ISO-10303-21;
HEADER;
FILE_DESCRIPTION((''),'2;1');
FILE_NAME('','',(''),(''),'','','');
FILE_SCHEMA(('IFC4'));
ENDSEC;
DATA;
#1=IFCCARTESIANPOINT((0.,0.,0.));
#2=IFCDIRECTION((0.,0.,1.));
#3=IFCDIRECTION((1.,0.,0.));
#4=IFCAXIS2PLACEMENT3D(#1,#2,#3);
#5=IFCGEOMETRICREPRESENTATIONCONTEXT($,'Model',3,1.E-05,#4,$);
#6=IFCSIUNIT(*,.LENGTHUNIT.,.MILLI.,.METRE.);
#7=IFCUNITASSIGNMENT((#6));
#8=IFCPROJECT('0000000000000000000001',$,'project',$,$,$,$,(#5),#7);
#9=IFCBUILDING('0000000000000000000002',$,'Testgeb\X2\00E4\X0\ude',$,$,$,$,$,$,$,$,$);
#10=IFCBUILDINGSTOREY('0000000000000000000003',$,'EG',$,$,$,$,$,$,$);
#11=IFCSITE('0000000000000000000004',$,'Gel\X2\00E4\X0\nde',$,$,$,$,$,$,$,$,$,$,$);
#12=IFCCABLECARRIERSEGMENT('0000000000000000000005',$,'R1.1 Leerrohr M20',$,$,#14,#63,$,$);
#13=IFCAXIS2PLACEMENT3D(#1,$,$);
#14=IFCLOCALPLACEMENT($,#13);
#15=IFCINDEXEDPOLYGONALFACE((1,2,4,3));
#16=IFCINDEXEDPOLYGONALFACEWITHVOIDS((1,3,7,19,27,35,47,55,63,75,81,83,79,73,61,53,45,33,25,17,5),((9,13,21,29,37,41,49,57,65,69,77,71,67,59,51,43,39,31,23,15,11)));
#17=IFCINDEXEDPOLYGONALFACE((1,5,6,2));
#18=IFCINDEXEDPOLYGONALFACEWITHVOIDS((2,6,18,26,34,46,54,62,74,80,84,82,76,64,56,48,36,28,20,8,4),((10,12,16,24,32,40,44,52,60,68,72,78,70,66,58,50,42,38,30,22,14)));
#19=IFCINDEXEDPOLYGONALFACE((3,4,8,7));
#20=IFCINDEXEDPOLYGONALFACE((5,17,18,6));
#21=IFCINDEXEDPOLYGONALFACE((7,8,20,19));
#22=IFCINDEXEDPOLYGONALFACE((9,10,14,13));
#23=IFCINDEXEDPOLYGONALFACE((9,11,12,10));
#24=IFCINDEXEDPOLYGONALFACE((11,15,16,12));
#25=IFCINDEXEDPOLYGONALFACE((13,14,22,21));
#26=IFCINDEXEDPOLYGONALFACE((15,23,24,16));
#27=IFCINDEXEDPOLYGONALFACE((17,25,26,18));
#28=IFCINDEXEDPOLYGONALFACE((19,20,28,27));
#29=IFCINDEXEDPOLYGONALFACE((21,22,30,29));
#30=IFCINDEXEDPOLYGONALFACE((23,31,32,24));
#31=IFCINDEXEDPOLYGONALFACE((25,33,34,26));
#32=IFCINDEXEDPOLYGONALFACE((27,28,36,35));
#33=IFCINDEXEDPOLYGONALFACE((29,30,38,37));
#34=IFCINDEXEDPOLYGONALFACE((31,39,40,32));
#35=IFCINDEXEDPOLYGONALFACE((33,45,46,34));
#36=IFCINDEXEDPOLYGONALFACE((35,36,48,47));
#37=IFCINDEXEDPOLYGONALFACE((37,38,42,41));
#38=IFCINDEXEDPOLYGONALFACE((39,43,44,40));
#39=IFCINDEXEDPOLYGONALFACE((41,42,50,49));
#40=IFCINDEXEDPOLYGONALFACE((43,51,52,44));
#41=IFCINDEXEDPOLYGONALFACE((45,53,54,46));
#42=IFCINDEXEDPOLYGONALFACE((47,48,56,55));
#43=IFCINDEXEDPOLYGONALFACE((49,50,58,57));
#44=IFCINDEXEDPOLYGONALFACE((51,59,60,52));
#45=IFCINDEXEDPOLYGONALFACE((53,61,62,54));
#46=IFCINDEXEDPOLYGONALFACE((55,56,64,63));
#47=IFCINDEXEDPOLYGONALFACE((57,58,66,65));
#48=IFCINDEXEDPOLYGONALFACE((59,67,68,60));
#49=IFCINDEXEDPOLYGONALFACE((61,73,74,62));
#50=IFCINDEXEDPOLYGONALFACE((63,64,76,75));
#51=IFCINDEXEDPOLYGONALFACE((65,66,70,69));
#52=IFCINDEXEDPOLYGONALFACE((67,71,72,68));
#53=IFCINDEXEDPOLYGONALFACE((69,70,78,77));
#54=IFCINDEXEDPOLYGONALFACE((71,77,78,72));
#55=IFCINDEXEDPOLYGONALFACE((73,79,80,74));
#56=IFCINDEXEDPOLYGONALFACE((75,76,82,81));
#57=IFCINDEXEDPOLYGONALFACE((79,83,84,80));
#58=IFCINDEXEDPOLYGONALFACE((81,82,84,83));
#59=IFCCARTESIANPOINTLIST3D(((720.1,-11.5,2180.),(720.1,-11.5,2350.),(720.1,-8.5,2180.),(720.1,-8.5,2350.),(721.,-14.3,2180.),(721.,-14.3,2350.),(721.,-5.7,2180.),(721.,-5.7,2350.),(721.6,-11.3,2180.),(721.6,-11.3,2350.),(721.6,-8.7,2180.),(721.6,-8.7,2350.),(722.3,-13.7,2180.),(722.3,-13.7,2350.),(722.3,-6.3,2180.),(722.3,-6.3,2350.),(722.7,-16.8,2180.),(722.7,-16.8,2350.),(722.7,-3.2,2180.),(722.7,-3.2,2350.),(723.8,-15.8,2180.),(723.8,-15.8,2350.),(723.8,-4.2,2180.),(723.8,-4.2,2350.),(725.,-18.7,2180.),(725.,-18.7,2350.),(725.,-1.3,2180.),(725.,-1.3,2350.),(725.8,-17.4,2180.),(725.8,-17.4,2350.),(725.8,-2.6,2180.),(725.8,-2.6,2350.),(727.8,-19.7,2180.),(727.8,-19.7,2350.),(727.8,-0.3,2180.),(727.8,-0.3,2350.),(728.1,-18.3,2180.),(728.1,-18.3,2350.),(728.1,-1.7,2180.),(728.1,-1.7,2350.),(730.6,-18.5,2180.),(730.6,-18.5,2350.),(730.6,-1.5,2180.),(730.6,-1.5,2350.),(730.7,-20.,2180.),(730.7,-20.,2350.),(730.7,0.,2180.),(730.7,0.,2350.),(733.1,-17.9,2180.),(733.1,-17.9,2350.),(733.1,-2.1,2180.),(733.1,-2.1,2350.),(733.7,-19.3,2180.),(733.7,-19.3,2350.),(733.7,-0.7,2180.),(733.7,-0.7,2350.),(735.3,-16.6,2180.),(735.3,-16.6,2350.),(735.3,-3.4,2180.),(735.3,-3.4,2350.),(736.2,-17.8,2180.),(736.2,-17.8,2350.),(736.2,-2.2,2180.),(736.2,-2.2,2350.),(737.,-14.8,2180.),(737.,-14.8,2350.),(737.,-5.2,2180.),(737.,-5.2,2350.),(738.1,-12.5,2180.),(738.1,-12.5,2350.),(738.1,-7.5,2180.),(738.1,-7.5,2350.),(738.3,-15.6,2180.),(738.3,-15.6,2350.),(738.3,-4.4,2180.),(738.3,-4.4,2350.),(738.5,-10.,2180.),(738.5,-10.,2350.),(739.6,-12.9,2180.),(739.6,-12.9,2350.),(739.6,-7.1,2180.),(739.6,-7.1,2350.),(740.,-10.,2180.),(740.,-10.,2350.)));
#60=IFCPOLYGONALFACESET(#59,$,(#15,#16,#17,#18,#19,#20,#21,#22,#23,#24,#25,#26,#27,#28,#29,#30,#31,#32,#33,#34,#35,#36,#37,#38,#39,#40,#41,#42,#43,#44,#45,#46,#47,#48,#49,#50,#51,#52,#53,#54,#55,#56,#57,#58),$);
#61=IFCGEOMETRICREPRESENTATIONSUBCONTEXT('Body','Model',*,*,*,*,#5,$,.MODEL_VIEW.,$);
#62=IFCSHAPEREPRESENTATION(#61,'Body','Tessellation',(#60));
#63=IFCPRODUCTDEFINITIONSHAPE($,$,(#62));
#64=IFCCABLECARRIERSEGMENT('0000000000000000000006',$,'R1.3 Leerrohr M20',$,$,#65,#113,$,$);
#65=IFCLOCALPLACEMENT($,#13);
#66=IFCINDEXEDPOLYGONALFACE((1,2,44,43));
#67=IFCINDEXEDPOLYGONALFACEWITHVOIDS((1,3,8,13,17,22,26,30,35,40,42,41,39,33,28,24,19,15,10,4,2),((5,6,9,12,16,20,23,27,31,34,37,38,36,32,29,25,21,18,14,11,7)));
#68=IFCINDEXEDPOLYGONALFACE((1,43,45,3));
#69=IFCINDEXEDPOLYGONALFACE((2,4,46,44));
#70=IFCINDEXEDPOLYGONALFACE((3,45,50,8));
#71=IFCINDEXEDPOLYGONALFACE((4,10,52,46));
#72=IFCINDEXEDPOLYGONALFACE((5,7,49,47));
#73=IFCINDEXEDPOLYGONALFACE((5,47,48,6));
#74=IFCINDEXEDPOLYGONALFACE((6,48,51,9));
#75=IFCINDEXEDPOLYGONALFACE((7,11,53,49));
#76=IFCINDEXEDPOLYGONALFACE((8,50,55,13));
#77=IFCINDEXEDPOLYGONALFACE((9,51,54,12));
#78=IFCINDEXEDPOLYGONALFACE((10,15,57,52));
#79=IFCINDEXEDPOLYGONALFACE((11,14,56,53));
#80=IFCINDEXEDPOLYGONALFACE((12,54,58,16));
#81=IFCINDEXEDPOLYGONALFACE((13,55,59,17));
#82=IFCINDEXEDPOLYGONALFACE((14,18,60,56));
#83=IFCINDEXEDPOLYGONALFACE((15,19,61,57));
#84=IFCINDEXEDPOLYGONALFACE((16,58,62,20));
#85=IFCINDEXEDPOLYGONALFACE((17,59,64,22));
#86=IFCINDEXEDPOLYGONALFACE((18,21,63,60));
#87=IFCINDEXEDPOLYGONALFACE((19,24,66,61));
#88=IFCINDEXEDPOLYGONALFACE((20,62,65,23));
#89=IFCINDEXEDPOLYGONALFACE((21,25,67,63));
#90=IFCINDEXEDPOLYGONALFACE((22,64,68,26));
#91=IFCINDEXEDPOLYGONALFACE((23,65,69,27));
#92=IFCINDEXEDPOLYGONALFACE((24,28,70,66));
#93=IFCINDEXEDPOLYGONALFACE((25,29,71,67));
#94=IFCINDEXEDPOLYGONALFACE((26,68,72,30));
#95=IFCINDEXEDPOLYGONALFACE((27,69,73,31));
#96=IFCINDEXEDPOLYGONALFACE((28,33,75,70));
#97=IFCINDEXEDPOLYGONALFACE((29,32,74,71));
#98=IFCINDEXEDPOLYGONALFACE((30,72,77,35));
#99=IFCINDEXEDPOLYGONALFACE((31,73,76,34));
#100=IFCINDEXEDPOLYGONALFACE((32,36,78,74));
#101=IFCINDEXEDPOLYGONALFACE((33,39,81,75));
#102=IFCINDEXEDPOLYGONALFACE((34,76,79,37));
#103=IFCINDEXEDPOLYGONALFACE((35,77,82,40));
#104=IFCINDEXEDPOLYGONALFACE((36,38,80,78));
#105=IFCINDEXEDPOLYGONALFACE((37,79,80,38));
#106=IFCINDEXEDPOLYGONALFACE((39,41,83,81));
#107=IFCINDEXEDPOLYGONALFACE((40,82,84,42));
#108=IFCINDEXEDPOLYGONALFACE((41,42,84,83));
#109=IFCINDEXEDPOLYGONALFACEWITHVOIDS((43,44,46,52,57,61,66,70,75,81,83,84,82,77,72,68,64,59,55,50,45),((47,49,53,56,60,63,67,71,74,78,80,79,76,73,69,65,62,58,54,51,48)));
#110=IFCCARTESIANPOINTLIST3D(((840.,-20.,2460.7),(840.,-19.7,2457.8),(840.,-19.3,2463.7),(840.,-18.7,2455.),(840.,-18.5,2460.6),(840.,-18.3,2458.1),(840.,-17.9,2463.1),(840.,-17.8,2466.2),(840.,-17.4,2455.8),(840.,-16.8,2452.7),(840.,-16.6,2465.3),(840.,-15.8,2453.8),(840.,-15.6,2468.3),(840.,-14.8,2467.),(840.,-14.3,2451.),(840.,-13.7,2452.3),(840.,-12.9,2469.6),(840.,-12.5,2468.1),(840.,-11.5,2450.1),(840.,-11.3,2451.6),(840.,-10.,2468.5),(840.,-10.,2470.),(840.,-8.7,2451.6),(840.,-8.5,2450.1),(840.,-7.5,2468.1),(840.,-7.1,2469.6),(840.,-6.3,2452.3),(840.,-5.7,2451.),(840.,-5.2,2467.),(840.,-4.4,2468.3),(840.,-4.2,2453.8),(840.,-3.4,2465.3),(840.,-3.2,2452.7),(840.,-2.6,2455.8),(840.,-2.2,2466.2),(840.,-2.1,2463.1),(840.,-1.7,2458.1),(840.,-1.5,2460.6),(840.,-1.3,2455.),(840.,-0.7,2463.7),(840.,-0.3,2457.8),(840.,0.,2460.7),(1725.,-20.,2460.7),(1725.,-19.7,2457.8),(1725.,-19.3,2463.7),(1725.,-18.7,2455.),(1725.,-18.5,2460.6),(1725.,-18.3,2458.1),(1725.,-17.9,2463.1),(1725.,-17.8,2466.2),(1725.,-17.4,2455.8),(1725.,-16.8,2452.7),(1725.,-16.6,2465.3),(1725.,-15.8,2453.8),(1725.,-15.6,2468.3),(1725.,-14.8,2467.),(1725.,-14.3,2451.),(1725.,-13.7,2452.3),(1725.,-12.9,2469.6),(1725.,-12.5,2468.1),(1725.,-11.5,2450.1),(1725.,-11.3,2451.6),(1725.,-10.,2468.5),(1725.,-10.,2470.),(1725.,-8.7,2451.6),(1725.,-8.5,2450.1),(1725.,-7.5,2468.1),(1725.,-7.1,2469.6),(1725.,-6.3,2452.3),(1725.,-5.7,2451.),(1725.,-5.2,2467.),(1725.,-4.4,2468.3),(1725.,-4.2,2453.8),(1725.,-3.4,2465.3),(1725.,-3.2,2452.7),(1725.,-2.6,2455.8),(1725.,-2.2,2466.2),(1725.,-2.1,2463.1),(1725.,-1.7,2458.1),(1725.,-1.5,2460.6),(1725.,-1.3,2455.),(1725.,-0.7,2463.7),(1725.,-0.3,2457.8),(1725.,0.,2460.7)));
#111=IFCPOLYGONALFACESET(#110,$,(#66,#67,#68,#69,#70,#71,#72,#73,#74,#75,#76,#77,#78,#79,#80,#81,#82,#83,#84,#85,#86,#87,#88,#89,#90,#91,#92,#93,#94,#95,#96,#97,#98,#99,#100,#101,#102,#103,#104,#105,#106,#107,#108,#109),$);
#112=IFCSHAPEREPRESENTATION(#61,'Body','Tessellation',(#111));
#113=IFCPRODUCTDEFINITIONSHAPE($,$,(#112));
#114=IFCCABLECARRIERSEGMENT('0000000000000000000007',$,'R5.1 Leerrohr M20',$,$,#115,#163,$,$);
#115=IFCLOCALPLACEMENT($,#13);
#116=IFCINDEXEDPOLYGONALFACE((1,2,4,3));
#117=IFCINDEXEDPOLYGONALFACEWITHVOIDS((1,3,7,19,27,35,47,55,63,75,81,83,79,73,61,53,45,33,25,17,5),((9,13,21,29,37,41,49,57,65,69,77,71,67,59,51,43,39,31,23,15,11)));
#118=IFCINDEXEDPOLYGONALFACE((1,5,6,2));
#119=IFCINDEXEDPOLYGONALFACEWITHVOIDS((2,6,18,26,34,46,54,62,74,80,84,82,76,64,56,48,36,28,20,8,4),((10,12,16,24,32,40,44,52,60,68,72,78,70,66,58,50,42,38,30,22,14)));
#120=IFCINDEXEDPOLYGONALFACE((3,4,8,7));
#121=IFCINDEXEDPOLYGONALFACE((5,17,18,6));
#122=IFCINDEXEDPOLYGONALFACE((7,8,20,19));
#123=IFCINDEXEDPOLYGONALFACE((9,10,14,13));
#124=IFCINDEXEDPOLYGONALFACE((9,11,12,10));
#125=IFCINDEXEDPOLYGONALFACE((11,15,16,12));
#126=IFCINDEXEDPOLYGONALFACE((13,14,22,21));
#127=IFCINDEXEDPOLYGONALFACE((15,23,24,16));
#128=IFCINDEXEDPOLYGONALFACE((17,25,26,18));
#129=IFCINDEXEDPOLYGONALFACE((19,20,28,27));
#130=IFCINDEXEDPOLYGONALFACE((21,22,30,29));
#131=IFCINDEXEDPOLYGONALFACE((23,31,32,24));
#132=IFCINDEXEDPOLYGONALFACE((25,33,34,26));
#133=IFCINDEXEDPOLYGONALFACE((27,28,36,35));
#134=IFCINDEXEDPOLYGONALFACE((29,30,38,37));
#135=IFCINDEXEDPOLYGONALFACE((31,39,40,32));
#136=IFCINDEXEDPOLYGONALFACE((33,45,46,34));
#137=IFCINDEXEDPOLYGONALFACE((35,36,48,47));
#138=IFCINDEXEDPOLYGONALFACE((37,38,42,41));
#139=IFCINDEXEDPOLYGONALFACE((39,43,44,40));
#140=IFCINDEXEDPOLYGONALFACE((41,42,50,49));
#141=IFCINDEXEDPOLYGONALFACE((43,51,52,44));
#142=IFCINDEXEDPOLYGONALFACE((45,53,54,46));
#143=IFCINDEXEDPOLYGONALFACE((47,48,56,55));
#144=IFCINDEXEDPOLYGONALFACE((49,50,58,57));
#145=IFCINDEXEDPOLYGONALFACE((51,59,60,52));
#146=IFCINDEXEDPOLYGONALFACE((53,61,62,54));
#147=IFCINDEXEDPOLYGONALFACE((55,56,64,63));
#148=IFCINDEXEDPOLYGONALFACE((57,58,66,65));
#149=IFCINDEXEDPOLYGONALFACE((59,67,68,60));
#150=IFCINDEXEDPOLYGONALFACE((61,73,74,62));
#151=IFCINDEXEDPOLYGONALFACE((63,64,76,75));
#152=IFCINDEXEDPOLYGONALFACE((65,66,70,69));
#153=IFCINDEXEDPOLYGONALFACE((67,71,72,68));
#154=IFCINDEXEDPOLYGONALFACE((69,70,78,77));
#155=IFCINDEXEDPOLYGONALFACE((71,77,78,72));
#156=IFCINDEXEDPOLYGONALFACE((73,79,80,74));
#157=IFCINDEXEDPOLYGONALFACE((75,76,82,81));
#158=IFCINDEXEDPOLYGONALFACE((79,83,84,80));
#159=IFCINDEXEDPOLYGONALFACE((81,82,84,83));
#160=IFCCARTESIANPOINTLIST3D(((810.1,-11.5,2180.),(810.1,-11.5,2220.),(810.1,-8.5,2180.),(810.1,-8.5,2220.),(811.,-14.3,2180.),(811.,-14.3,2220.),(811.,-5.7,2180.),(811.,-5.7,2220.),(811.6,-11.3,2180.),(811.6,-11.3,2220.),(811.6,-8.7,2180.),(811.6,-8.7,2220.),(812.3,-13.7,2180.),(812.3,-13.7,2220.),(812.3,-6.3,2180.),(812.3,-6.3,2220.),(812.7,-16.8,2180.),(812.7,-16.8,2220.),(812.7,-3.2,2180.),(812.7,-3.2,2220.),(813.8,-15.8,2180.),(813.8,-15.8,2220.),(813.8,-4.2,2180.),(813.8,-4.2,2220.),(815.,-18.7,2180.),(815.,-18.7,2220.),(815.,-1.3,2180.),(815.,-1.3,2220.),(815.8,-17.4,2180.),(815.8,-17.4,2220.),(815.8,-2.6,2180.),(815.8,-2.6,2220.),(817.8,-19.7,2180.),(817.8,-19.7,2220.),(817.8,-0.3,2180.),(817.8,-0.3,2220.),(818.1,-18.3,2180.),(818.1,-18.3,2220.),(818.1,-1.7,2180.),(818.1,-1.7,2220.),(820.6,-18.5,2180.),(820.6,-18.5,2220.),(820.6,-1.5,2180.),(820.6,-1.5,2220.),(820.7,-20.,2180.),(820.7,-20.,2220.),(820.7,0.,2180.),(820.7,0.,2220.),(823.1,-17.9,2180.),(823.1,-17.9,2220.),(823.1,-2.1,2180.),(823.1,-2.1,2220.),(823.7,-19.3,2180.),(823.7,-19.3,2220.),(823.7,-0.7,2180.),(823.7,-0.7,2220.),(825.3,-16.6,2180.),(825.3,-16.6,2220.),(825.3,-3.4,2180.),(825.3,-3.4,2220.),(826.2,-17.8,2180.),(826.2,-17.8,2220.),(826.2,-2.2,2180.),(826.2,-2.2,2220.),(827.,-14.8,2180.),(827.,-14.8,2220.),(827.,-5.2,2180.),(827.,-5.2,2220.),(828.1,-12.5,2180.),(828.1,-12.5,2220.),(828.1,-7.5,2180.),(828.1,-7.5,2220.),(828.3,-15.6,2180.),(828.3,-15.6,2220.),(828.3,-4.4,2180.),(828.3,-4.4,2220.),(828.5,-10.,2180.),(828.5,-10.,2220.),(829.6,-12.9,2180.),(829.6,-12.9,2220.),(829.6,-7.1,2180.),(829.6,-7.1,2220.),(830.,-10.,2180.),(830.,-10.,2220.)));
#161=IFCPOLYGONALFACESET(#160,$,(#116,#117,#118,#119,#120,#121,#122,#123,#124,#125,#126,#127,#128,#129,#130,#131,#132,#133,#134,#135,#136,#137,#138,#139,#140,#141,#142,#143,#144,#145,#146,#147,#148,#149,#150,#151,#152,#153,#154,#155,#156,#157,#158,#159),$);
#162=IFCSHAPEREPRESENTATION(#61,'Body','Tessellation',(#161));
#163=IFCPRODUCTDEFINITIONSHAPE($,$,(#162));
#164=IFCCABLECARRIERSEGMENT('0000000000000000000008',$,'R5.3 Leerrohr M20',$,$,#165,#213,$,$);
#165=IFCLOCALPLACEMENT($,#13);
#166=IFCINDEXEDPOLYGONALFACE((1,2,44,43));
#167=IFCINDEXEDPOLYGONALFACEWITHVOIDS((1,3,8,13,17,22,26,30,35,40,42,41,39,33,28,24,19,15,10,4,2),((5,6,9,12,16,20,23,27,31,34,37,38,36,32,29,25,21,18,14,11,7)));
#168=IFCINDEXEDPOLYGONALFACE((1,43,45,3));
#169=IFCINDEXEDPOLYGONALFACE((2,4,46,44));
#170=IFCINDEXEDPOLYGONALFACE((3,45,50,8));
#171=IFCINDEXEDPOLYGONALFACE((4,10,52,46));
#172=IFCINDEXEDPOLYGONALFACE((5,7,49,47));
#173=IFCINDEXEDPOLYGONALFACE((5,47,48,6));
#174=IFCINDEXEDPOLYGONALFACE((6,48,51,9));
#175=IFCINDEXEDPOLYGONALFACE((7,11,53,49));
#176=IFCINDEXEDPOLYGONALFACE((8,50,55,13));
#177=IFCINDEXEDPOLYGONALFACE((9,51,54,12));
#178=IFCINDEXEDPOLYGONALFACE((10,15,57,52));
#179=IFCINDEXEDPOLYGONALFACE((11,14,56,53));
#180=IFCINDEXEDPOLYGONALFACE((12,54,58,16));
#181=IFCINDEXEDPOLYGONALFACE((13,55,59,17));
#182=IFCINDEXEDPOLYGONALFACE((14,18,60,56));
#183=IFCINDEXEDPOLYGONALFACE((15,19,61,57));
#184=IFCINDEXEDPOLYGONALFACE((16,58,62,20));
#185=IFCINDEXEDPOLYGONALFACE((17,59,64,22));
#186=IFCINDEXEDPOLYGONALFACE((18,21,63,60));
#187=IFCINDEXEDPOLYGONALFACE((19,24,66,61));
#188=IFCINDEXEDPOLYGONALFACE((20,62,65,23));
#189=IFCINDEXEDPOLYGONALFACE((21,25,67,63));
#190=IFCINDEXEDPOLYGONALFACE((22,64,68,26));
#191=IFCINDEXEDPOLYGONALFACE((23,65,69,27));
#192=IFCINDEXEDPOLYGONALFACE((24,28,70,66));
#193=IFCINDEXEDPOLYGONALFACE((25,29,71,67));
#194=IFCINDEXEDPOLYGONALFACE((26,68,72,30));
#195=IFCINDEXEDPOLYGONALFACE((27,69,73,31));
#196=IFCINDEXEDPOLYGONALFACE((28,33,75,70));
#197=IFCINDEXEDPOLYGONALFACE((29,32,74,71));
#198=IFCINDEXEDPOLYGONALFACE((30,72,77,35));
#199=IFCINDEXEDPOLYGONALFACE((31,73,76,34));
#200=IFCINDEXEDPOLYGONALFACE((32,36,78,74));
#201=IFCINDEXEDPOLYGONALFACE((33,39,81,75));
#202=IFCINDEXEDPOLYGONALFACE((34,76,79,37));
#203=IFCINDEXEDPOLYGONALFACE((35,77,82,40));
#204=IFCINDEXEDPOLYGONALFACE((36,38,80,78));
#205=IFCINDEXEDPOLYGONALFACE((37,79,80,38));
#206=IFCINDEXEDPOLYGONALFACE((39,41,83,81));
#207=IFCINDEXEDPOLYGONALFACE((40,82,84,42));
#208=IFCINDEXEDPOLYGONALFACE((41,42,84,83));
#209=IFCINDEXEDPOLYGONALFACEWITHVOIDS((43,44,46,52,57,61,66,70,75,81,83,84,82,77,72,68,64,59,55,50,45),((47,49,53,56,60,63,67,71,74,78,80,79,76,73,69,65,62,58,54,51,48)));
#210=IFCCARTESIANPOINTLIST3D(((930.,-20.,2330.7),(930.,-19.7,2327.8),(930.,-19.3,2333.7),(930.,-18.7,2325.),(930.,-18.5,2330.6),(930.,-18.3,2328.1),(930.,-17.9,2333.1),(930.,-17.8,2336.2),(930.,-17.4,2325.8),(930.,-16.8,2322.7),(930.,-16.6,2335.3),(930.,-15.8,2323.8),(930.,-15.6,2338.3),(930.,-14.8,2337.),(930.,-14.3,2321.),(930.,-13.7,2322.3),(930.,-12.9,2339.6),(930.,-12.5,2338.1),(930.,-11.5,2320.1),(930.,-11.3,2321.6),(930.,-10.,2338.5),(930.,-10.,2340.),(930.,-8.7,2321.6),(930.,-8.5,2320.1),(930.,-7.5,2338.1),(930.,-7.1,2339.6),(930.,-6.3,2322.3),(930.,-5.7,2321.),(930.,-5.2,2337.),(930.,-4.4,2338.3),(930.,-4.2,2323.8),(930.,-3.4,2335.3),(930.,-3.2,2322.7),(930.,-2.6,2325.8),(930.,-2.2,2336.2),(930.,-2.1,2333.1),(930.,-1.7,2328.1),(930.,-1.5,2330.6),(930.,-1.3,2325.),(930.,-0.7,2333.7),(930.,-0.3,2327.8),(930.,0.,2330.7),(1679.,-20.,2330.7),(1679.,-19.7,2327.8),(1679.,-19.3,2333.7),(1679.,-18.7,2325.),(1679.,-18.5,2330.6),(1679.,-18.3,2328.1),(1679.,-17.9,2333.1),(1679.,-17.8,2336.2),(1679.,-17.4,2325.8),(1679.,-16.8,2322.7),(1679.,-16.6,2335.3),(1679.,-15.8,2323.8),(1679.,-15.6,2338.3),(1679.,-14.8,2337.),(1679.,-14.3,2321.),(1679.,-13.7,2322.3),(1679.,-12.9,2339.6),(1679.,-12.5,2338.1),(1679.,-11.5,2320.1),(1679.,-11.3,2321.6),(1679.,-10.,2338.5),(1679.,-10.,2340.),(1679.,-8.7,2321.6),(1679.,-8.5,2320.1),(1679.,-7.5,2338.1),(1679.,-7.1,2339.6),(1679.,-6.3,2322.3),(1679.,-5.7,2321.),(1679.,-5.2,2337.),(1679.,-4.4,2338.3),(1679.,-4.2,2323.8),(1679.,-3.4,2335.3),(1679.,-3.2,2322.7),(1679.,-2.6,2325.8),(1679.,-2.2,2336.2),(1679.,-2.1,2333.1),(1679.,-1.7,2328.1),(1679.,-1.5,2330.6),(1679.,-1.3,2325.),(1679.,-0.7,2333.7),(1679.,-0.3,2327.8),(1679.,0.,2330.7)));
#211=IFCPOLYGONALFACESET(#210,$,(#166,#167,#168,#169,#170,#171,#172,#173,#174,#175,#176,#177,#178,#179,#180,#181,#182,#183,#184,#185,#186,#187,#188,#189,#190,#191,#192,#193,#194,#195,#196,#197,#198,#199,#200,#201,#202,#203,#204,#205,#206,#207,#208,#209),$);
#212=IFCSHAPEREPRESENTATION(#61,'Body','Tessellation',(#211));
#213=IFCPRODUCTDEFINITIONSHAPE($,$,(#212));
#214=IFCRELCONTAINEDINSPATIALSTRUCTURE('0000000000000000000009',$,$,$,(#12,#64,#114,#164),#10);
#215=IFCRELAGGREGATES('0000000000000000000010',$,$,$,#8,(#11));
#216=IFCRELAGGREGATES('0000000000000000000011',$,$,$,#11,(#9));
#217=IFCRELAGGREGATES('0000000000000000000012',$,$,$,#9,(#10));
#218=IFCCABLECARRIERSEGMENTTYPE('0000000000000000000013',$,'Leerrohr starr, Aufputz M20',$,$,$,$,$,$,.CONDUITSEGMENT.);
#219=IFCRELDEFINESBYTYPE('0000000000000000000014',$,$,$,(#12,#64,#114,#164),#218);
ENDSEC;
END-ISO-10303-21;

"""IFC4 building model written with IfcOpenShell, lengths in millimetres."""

from ifc_helpers import new_model, si_unit, frame, origin_with_axes, place, context, subcontext, project, spatial, hollow_circle, extrude, type_object, element, save


model = new_model("IFC4")

# Units and contexts
model_context = context("Model", 3, precision=1e-05, world=origin_with_axes())
body_context = subcontext(model_context, "Body", "Model", "MODEL_VIEW")
ifc_project = project(units=[si_unit("LENGTHUNIT", "METRE", prefix="MILLI")], contexts=[model_context])

# Site, building, storey
site = spatial("IfcSite", under=ifc_project, Name="Gelände")
building = spatial("IfcBuilding", under=site, Name="Testgebäude")
storey = spatial("IfcBuildingStorey", under=building, Name="EG")

# Cable carrier segments
cable_carrier_segment_type_1 = type_object("IfcCableCarrierSegmentType", Name="Leerrohr starr, Aufputz M20", PredefinedType="CONDUITSEGMENT")
cable_carrier_segment_1_placement = place(None, frame((730.0, -10.0, 2180.0), z_axis=(0.0, 0.0, 1.0), x_axis=(1.0, 0.0, 0.0)))
element("IfcCableCarrierSegment", 1, at=cable_carrier_segment_1_placement, inside=storey, type_object=cable_carrier_segment_type_1, Name="R1.1 Leerrohr M20", context=body_context, shape_type="SweptSolid", body=[
    extrude(hollow_circle(Radius=10.0, WallThickness=1.5), None, (0.0, 0.0, 1.0), 170.0),
])
cable_carrier_segment_2_placement = place(None, frame((840.0, -10.0, 2460.0), z_axis=(1.0, 0.0, 0.0), x_axis=(0.0, 0.0, 1.0)))
element("IfcCableCarrierSegment", 2, at=cable_carrier_segment_2_placement, inside=storey, type_object=cable_carrier_segment_type_1, Name="R1.3 Leerrohr M20", context=body_context, shape_type="SweptSolid", body=[
    extrude(hollow_circle(Radius=10.0, WallThickness=1.5), None, (0.0, 0.0, 1.0), 885.0),
])
cable_carrier_segment_3_placement = place(None, frame((820.0, -10.0, 2180.0), z_axis=(0.0, 0.0, 1.0), x_axis=(1.0, 0.0, 0.0)))
element("IfcCableCarrierSegment", 3, at=cable_carrier_segment_3_placement, inside=storey, type_object=cable_carrier_segment_type_1, Name="R5.1 Leerrohr M20", context=body_context, shape_type="SweptSolid", body=[
    extrude(hollow_circle(Radius=10.0, WallThickness=1.5), None, (0.0, 0.0, 1.0), 40.0),
])
cable_carrier_segment_4_placement = place(None, frame((930.0, -10.0, 2330.0), z_axis=(1.0, 0.0, 0.0), x_axis=(0.0, 0.0, 1.0)))
element("IfcCableCarrierSegment", 4, at=cable_carrier_segment_4_placement, inside=storey, type_object=cable_carrier_segment_type_1, Name="R5.3 Leerrohr M20", context=body_context, shape_type="SweptSolid", body=[
    extrude(hollow_circle(Radius=10.0, WallThickness=1.5), None, (0.0, 0.0, 1.0), 749.0),
])

save(model, "model.ifc")
